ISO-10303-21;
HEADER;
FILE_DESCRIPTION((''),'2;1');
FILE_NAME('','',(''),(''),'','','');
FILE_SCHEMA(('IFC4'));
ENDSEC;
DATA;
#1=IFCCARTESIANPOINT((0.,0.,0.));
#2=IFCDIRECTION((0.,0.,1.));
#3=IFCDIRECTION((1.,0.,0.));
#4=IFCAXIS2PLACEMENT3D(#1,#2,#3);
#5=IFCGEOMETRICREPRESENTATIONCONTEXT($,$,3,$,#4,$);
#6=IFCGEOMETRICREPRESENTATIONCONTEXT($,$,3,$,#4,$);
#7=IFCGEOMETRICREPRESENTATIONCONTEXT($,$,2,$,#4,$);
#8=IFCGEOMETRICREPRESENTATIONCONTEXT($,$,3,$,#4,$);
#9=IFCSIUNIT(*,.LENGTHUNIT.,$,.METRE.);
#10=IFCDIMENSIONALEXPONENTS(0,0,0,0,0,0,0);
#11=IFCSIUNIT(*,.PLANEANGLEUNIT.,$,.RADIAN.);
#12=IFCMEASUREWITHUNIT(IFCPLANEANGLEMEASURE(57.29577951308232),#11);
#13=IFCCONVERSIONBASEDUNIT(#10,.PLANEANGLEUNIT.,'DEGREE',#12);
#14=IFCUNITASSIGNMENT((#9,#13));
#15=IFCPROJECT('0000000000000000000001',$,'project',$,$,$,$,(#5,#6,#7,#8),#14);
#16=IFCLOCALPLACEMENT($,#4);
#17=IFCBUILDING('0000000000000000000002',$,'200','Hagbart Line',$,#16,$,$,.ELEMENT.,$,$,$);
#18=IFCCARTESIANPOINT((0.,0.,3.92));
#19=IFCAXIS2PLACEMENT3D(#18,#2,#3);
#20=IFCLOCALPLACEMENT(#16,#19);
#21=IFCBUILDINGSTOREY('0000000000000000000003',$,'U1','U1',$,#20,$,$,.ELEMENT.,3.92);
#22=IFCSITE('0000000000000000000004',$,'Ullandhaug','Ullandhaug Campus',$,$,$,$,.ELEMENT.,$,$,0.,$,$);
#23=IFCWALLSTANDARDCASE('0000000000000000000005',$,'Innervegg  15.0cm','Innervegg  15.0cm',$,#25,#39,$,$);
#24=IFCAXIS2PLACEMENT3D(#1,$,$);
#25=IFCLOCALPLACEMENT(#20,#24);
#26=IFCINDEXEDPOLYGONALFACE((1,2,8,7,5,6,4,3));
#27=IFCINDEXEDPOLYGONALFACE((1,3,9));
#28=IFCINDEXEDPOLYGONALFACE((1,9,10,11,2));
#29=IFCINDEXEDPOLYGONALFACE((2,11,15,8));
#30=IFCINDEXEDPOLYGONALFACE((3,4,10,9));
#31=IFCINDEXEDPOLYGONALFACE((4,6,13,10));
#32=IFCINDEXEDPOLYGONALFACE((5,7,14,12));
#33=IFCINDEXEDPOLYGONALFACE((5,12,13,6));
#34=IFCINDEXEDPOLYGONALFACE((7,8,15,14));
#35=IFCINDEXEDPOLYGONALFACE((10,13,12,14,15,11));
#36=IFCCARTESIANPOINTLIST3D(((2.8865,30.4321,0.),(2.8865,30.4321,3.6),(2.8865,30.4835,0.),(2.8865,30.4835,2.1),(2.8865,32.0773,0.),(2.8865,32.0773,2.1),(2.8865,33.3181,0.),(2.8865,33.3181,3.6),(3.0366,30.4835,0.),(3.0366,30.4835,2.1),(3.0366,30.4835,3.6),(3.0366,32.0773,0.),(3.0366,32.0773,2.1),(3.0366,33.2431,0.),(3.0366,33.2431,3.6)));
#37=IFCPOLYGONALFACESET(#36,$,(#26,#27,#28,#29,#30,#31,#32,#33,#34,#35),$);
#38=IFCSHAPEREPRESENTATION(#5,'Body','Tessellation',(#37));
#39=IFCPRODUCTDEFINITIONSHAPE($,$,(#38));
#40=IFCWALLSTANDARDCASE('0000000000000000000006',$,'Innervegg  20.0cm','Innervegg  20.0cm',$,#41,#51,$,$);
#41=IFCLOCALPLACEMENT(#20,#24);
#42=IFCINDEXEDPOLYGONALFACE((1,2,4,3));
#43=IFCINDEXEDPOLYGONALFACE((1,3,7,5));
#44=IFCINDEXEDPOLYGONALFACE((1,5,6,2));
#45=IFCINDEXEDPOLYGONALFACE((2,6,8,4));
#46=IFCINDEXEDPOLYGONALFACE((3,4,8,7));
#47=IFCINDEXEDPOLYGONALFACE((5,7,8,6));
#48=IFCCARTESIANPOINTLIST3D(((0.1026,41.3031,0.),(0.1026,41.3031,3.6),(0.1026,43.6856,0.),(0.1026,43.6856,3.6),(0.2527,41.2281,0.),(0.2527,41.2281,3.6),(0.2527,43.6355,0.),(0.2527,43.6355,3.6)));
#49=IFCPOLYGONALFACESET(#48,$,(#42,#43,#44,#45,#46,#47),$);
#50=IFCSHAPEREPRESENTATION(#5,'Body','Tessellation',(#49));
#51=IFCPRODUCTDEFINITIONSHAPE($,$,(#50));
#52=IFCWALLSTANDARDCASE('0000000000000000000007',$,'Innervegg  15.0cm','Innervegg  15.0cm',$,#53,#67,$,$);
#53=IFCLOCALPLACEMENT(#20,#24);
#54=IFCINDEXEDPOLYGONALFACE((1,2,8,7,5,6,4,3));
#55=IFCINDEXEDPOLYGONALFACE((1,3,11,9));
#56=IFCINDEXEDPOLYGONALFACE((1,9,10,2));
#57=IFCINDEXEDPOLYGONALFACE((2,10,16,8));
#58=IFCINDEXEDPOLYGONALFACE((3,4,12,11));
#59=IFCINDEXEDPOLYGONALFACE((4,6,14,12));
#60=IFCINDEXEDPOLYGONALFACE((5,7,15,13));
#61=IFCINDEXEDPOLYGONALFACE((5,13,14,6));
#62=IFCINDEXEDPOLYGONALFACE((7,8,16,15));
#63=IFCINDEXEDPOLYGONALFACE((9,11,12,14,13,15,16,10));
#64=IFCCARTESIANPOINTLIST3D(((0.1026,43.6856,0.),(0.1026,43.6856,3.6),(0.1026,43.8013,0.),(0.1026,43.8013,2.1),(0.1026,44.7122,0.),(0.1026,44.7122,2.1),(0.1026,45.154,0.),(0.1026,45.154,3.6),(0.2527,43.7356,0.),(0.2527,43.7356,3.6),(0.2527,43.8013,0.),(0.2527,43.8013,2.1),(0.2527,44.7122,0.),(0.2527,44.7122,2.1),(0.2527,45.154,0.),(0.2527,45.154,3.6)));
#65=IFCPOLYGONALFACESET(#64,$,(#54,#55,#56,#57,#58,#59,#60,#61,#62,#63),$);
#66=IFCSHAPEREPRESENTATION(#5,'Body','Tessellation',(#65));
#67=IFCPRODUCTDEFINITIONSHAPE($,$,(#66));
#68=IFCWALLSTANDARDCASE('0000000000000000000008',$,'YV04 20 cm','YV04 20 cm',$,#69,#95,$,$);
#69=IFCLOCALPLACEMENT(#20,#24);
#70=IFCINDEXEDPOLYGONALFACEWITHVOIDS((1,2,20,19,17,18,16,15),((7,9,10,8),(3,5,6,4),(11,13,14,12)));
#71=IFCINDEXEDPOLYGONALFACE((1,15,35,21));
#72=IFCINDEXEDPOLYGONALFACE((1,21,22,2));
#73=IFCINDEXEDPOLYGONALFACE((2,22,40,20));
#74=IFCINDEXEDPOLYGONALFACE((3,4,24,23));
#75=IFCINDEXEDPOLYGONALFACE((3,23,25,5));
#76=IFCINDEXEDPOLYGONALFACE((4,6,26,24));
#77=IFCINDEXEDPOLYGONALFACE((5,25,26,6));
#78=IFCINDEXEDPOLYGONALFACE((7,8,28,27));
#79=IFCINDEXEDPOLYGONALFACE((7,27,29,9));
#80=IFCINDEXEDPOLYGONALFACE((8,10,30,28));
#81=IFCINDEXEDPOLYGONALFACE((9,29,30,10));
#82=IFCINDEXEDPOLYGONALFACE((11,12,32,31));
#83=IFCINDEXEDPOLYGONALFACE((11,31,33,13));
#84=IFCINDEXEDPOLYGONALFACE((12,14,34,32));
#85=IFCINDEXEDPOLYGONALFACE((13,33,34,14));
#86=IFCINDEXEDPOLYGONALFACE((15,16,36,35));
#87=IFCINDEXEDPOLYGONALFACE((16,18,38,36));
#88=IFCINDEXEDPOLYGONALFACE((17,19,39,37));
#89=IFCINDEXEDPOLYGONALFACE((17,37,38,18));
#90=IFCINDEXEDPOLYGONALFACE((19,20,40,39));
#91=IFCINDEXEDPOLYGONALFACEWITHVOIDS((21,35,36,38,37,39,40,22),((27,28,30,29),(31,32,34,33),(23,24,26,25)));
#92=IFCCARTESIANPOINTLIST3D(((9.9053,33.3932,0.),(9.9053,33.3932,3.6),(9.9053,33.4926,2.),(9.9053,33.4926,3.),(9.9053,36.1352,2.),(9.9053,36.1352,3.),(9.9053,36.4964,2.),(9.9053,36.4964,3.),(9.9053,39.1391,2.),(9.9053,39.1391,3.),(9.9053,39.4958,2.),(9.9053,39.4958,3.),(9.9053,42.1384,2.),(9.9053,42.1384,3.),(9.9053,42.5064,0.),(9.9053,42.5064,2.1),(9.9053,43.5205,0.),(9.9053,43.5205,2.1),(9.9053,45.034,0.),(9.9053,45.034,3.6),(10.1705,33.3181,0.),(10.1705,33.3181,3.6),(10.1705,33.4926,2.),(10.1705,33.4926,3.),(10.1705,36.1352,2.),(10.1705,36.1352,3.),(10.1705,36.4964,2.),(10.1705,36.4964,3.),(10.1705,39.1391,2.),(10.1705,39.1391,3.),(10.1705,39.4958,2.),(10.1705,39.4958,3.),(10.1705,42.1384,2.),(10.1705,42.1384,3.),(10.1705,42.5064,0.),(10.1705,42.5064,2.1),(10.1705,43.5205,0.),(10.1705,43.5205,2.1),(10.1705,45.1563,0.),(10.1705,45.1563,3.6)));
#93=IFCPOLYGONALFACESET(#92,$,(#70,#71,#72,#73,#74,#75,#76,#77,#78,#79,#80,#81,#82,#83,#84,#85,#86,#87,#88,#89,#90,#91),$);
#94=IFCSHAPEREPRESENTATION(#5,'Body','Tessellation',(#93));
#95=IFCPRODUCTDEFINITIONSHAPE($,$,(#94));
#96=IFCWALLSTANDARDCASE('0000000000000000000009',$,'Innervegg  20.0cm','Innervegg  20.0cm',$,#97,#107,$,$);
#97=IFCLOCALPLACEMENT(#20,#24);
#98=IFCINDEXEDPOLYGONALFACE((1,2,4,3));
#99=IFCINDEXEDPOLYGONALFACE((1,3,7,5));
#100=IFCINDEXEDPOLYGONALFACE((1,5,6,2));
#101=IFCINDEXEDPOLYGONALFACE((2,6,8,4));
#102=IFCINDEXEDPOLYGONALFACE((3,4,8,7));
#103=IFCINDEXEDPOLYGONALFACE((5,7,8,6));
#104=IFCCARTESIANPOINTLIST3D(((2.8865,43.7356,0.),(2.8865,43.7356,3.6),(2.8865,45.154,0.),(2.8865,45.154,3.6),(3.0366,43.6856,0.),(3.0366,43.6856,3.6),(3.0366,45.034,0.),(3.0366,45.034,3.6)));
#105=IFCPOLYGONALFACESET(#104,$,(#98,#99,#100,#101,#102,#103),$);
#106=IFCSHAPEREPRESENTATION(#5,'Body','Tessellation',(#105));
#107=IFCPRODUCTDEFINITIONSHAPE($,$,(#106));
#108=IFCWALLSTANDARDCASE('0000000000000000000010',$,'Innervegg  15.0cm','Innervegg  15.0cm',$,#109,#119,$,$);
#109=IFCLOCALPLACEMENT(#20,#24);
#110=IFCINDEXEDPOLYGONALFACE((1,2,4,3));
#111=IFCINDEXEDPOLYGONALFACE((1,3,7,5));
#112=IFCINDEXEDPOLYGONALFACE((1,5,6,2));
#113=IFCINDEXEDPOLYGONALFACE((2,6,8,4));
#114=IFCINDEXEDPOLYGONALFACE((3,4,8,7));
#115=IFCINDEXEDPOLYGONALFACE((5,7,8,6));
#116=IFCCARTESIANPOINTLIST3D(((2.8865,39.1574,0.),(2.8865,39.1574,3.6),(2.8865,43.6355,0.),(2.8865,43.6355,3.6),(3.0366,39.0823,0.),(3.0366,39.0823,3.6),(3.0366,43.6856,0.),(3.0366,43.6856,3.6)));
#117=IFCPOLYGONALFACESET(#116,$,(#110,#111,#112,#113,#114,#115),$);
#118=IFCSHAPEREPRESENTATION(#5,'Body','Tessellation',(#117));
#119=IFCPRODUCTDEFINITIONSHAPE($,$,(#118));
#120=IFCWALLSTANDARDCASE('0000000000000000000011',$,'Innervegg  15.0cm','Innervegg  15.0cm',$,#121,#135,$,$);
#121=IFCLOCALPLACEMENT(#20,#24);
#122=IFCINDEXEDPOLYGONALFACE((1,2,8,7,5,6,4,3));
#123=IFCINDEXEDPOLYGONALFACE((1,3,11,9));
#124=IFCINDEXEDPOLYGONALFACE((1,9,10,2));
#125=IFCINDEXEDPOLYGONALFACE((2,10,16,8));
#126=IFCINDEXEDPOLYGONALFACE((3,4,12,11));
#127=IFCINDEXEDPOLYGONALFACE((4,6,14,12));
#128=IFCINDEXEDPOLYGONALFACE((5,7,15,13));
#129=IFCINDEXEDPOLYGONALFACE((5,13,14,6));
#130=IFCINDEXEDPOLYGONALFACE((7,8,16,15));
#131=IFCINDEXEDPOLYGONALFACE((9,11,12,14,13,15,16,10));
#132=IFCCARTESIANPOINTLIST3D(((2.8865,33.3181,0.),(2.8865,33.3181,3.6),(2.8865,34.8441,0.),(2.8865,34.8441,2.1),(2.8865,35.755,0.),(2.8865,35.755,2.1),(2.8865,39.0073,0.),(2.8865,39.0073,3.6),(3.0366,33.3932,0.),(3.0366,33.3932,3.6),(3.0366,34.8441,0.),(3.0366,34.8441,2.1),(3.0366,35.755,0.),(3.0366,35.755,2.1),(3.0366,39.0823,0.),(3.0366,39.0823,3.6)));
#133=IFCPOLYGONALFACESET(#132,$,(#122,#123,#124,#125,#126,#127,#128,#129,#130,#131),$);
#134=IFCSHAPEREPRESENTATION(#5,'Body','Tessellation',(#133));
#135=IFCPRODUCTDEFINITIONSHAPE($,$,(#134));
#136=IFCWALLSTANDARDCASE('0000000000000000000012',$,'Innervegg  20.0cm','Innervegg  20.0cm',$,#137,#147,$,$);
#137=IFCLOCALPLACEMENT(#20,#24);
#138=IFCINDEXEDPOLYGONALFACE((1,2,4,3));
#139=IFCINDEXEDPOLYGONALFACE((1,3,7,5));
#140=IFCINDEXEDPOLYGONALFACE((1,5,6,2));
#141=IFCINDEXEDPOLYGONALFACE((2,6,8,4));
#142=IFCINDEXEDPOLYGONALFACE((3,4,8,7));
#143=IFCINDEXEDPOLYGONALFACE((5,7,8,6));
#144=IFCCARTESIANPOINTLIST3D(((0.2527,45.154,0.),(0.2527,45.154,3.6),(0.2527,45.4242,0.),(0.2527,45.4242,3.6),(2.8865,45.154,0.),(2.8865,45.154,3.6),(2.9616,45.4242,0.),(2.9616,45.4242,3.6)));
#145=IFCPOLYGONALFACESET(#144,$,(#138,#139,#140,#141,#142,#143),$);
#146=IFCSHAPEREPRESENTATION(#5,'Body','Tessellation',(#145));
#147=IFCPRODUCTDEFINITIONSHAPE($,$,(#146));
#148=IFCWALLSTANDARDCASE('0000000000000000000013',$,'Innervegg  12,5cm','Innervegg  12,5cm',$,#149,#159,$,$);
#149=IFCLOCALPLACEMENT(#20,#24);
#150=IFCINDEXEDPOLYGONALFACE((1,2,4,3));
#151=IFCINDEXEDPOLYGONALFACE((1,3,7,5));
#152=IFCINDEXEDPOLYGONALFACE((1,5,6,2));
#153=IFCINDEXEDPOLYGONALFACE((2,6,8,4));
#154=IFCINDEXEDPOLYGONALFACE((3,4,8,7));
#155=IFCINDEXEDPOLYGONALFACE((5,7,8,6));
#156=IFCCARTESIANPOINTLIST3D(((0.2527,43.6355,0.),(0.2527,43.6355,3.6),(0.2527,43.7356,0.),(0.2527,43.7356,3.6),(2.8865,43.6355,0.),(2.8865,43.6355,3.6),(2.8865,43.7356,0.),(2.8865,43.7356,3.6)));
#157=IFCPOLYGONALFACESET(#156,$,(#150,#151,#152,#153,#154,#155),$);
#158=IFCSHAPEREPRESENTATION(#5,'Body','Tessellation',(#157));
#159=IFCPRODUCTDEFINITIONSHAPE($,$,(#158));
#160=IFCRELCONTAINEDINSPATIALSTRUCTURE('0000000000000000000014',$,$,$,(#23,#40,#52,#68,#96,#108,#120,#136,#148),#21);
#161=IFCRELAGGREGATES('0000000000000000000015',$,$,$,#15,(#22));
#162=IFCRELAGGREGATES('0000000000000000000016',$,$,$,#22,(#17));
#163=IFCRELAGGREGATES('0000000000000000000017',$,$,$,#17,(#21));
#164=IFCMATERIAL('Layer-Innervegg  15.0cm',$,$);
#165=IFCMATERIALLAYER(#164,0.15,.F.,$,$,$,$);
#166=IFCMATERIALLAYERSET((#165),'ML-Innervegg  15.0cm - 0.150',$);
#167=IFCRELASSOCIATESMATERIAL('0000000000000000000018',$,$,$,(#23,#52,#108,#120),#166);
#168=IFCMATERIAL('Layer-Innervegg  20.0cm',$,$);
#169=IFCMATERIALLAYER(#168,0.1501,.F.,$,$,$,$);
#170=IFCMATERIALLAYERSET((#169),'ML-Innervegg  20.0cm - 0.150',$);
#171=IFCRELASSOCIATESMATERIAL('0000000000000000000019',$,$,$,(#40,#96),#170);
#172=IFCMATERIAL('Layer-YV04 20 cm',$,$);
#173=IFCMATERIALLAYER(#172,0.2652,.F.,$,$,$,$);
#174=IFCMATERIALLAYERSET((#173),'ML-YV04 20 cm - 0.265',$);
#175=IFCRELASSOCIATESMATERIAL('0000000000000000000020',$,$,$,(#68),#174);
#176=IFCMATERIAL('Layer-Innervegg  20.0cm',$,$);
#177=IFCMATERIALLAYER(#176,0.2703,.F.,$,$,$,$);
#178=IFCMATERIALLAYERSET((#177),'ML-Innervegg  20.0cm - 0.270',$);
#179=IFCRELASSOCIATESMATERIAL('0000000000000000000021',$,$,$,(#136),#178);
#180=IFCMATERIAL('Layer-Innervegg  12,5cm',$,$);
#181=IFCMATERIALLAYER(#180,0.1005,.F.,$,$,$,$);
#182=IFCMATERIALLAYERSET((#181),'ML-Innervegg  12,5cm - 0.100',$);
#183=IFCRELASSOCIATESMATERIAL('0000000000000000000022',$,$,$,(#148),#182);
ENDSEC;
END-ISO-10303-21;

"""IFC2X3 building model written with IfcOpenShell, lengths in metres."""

from ifc_helpers import new_model, entity, si_unit, converted_unit, frame, origin_with_axes, place, context, project, spatial, polyline, outline, extrude, material, layer, layer_set, layer_usage, element, save


model = new_model("IFC2X3")

# Units and contexts
context_of_model_1 = context(None, 3, world=origin_with_axes())
context_of_model_2 = context(None, 3, world=origin_with_axes())
context_of_model_3 = context(None, 2, world=origin_with_axes())
context_of_model_4 = context(None, 3, world=origin_with_axes())
ifc_project = project(units=[si_unit("LENGTHUNIT", "METRE"), converted_unit("PLANEANGLEUNIT", "DEGREE", entity("IfcPlaneAngleMeasure", 57.29577951308232), si_unit("PLANEANGLEUNIT", "RADIAN"), dimensions=[0, 0, 0, 0, 0, 0, 0])], contexts=[context_of_model_1, context_of_model_2, context_of_model_3, context_of_model_4])

# Site, building, storey
site = spatial("IfcSite", under=ifc_project, Name="Ullandhaug", Description="Ullandhaug Campus", CompositionType="ELEMENT", RefElevation=0.0)
building_placement = place(None, origin_with_axes())
building = spatial("IfcBuilding", under=site, at=building_placement, Name="200", Description="Hagbart Line", CompositionType="ELEMENT")
storey_placement = place(building_placement, frame((0.0, 0.0, 3.92), z_axis=(0.0, 0.0, 1.0), x_axis=(1.0, 0.0, 0.0)))
storey = spatial("IfcBuildingStorey", under=building, at=storey_placement, Name="U1", Description="U1", CompositionType="ELEMENT", Elevation=3.92)

# Shared definitions
ifc_material_1 = material(Name="Layer-Innervegg  15.0cm")
ifc_layer_1 = layer(ifc_material_1, 0.15, ventilated=False)
ifc_layer_set_1 = layer_set([ifc_layer_1], Name="ML-Innervegg  15.0cm - 0.150")
ifc_layer_usage_1 = layer_usage(ifc_layer_set_1, "AXIS2", "POSITIVE", 0.0)

# Wall, opening
wall_1_placement = place(storey_placement, frame((2.8865, 33.3181, 0.0), z_axis=(0.0, 0.0, 1.0), x_axis=(0.0, -1.0, 0.0)))
wall_1 = element("IfcWallStandardCase", 1, at=wall_1_placement, inside=storey, material=ifc_layer_usage_1, Name="Innervegg  15.0cm", Description="Innervegg  15.0cm", context=context_of_model_1, shape_type="SweptSolid", body=[
    extrude(outline(polyline([(0.0, 0.0), (2.8861, 0.0), (2.8347, 0.1502), (0.0751, 0.1502), (0.0, 0.0)])), frame((0.0, 0.0, 0.0), z_axis=(0.0, 0.0, 1.0), x_axis=(1.0, 0.0, 0.0)), (0.0, 0.0, 1.0), 3.6),
])
opening_1_placement = place(wall_1_placement, frame((1.2408, 0.1502, 0.0), z_axis=(0.0, 0.0, 1.0), x_axis=(1.0, 0.0, 0.0)))
element("IfcOpeningElement", 2, at=opening_1_placement, cuts=wall_1, context=context_of_model_1, shape_type="SweptSolid", body=[
    extrude(outline(polyline([(0.0, 0.0), (2.1, 0.0), (2.1, 1.5938), (0.0, 1.5938), (0.0, 0.0)])), frame((0.0, 0.0, 0.0), z_axis=(0.0, 1.0, 0.0), x_axis=(0.0, 0.0, 1.0)), (0.0, 0.0, -1.0), 0.1502),
])

# Wall
ifc_material_2 = material(Name="Layer-Innervegg  20.0cm")
ifc_layer_2 = layer(ifc_material_2, 0.1501, ventilated=False)
ifc_layer_set_2 = layer_set([ifc_layer_2], Name="ML-Innervegg  20.0cm - 0.150")
ifc_layer_usage_2 = layer_usage(ifc_layer_set_2, "AXIS2", "POSITIVE", 0.0)
wall_2_placement = place(storey_placement, frame((0.2527, 41.2281, 0.0), z_axis=(0.0, 0.0, 1.0), x_axis=(0.0, 1.0, 0.0)))
element("IfcWallStandardCase", 3, at=wall_2_placement, inside=storey, material=ifc_layer_usage_2, Name="Innervegg  20.0cm", Description="Innervegg  20.0cm", context=context_of_model_1, shape_type="SweptSolid", body=[
    extrude(outline(polyline([(0.0, 0.0), (2.4075, 0.0), (2.4575, 0.1501), (0.0751, 0.1501), (0.0, 0.0)])), frame((0.0, 0.0, 0.0), z_axis=(0.0, 0.0, 1.0), x_axis=(1.0, 0.0, 0.0)), (0.0, 0.0, 1.0), 3.6),
])

# Wall, opening
wall_3_placement = place(storey_placement, frame((0.2527, 43.7356, 0.0), z_axis=(0.0, 0.0, 1.0), x_axis=(0.0, 1.0, 0.0)))
wall_3 = element("IfcWallStandardCase", 4, at=wall_3_placement, inside=storey, material=ifc_layer_usage_1, Name="Innervegg  15.0cm", Description="Innervegg  15.0cm", context=context_of_model_1, shape_type="SweptSolid", body=[
    extrude(outline(polyline([(0.0, 0.0), (1.4184, 0.0), (1.4184, 0.1501), (-0.05, 0.1502), (0.0, 0.0)])), frame((0.0, 0.0, 0.0), z_axis=(0.0, 0.0, 1.0), x_axis=(1.0, 0.0, 0.0)), (0.0, 0.0, 1.0), 3.6),
])
opening_2_placement = place(wall_3_placement, frame((0.0656, 0.1502, 0.0), z_axis=(0.0, 0.0, 1.0), x_axis=(1.0, 0.0, 0.0)))
element("IfcOpeningElement", 5, at=opening_2_placement, cuts=wall_3, context=context_of_model_1, shape_type="SweptSolid", body=[
    extrude(outline(polyline([(0.0, 0.0), (2.1, 0.0), (2.1, 0.9109), (0.0, 0.9109), (0.0, 0.0)])), frame((0.0, 0.0, 0.0), z_axis=(0.0, 1.0, 0.0), x_axis=(0.0, 0.0, 1.0)), (0.0, 0.0, -1.0), 0.1501),
])

# Wall, openings
ifc_material_3 = material(Name="Layer-YV04 20 cm")
ifc_layer_3 = layer(ifc_material_3, 0.2652, ventilated=False)
ifc_layer_set_3 = layer_set([ifc_layer_3], Name="ML-YV04 20 cm - 0.265")
ifc_layer_usage_3 = layer_usage(ifc_layer_set_3, "AXIS2", "POSITIVE", 0.0)
wall_4_placement = place(storey_placement, frame((10.1705, 33.3181, 0.0), z_axis=(0.0, 0.0, 1.0), x_axis=(0.0, 1.0, 0.0)))
wall_4 = element("IfcWallStandardCase", 6, at=wall_4_placement, inside=storey, material=ifc_layer_usage_3, Name="YV04 20 cm", Description="YV04 20 cm", context=context_of_model_1, shape_type="SweptSolid", body=[
    extrude(outline(polyline([(0.0, 0.0), (11.8382, 0.0), (11.7158, 0.2652), (0.0751, 0.2652), (0.0, 0.0)])), frame((0.0, 0.0, 0.0), z_axis=(0.0, 0.0, 1.0), x_axis=(1.0, 0.0, 0.0)), (0.0, 0.0, 1.0), 3.6),
])
opening_3_placement = place(wall_4_placement, frame((9.1883, 0.2652, 0.0), z_axis=(0.0, 0.0, 1.0), x_axis=(1.0, 0.0, 0.0)))
element("IfcOpeningElement", 7, at=opening_3_placement, cuts=wall_4, context=context_of_model_1, shape_type="SweptSolid", body=[
    extrude(outline(polyline([(0.0, 0.0), (2.1, 0.0), (2.1, 1.0141), (0.0, 1.0141), (0.0, 0.0)])), frame((0.0, 0.0, 0.0), z_axis=(0.0, 1.0, 0.0), x_axis=(0.0, 0.0, 1.0)), (0.0, 0.0, -1.0), 0.2652),
])
opening_4_placement = place(wall_4_placement, frame((0.1744, 0.2652, 2.0), z_axis=(0.0, 0.0, 1.0), x_axis=(1.0, 0.0, 0.0)))
element("IfcOpeningElement", 8, at=opening_4_placement, cuts=wall_4, context=context_of_model_1, shape_type="SweptSolid", body=[
    extrude(outline(polyline([(0.0, 0.0), (1.0, 0.0), (1.0, 2.6426), (0.0, 2.6426), (0.0, 0.0)])), frame((0.0, 0.0, 0.0), z_axis=(0.0, 1.0, 0.0), x_axis=(0.0, 0.0, 1.0)), (0.0, 0.0, -1.0), 0.2652),
])
opening_5_placement = place(wall_4_placement, frame((3.1783, 0.2652, 2.0), z_axis=(0.0, 0.0, 1.0), x_axis=(1.0, 0.0, 0.0)))
element("IfcOpeningElement", 9, at=opening_5_placement, cuts=wall_4, context=context_of_model_1, shape_type="SweptSolid", body=[
    extrude(outline(polyline([(0.0, 0.0), (1.0, 0.0), (1.0, 2.6426), (0.0, 2.6426), (0.0, 0.0)])), frame((0.0, 0.0, 0.0), z_axis=(0.0, 1.0, 0.0), x_axis=(0.0, 0.0, 1.0)), (0.0, 0.0, -1.0), 0.2652),
])
opening_6_placement = place(wall_4_placement, frame((6.1776, 0.2652, 2.0), z_axis=(0.0, 0.0, 1.0), x_axis=(1.0, 0.0, 0.0)))
element("IfcOpeningElement", 10, at=opening_6_placement, cuts=wall_4, context=context_of_model_1, shape_type="SweptSolid", body=[
    extrude(outline(polyline([(0.0, 0.0), (1.0, 0.0), (1.0, 2.6426), (0.0, 2.6426), (0.0, 0.0)])), frame((0.0, 0.0, 0.0), z_axis=(0.0, 1.0, 0.0), x_axis=(0.0, 0.0, 1.0)), (0.0, 0.0, -1.0), 0.2652),
])

# Walls
wall_5_placement = place(storey_placement, frame((2.8865, 45.154, 0.0), z_axis=(0.0, 0.0, 1.0), x_axis=(0.0, -1.0, 0.0)))
element("IfcWallStandardCase", 11, at=wall_5_placement, inside=storey, material=ifc_layer_usage_2, Name="Innervegg  20.0cm", Description="Innervegg  20.0cm", context=context_of_model_1, shape_type="SweptSolid", body=[
    extrude(outline(polyline([(0.0, 0.0), (1.4184, 0.0), (1.4684, 0.1501), (0.12, 0.1501), (0.0, 0.0)])), frame((0.0, 0.0, 0.0), z_axis=(0.0, 0.0, 1.0), x_axis=(1.0, 0.0, 0.0)), (0.0, 0.0, 1.0), 3.6),
])
wall_6_placement = place(storey_placement, frame((2.8865, 43.6355, 0.0), z_axis=(0.0, 0.0, 1.0), x_axis=(0.0, -1.0, 0.0)))
element("IfcWallStandardCase", 12, at=wall_6_placement, inside=storey, material=ifc_layer_usage_1, Name="Innervegg  15.0cm", Description="Innervegg  15.0cm", context=context_of_model_1, shape_type="SweptSolid", body=[
    extrude(outline(polyline([(0.0, 0.0), (4.4781, 0.0), (4.5532, 0.1501), (-0.05, 0.1501), (0.0, 0.0)])), frame((0.0, 0.0, 0.0), z_axis=(0.0, 0.0, 1.0), x_axis=(1.0, 0.0, 0.0)), (0.0, 0.0, 1.0), 3.6),
])

# Wall, opening
wall_7_placement = place(storey_placement, frame((2.8865, 39.0073, 0.0), z_axis=(0.0, 0.0, 1.0), x_axis=(0.0, -1.0, 0.0)))
wall_7 = element("IfcWallStandardCase", 13, at=wall_7_placement, inside=storey, material=ifc_layer_usage_1, Name="Innervegg  15.0cm", Description="Innervegg  15.0cm", context=context_of_model_1, shape_type="SweptSolid", body=[
    extrude(outline(polyline([(0.0, 0.0), (5.6891, 0.0), (5.614, 0.1502), (-0.0751, 0.1502), (0.0, 0.0)])), frame((0.0, 0.0, 0.0), z_axis=(0.0, 0.0, 1.0), x_axis=(1.0, 0.0, 0.0)), (0.0, 0.0, 1.0), 3.6),
])
opening_7_placement = place(wall_7_placement, frame((3.2523, 0.1502, 0.0), z_axis=(0.0, 0.0, 1.0), x_axis=(1.0, 0.0, 0.0)))
element("IfcOpeningElement", 14, at=opening_7_placement, cuts=wall_7, context=context_of_model_1, shape_type="SweptSolid", body=[
    extrude(outline(polyline([(0.0, 0.0), (2.1, 0.0), (2.1, 0.9109), (0.0, 0.9109), (0.0, 0.0)])), frame((0.0, 0.0, 0.0), z_axis=(0.0, 1.0, 0.0), x_axis=(0.0, 0.0, 1.0)), (0.0, 0.0, -1.0), 0.1502),
])

# Walls
ifc_material_4 = material(Name="Layer-Innervegg  20.0cm")
ifc_layer_4 = layer(ifc_material_4, 0.2703, ventilated=False)
ifc_layer_set_4 = layer_set([ifc_layer_4], Name="ML-Innervegg  20.0cm - 0.270")
ifc_layer_usage_4 = layer_usage(ifc_layer_set_4, "AXIS2", "POSITIVE", 0.0)
wall_8_placement = place(storey_placement, frame((0.2527, 45.154, 0.0), z_axis=(0.0, 0.0, 1.0), x_axis=(1.0, 0.0, 0.0)))
element("IfcWallStandardCase", 15, at=wall_8_placement, inside=storey, material=ifc_layer_usage_4, Name="Innervegg  20.0cm", Description="Innervegg  20.0cm", context=context_of_model_1, shape_type="SweptSolid", body=[
    extrude(outline(polyline([(0.0, 0.0), (2.6338, 0.0), (2.7088, 0.2703), (0.0, 0.2703), (0.0, 0.0)])), origin_with_axes(), (0.0, 0.0, 1.0), 3.6),
])
ifc_material_5 = material(Name="Layer-Innervegg  12,5cm")
ifc_layer_5 = layer(ifc_material_5, 0.1005, ventilated=False)
ifc_layer_set_5 = layer_set([ifc_layer_5], Name="ML-Innervegg  12,5cm - 0.100")
ifc_layer_usage_5 = layer_usage(ifc_layer_set_5, "AXIS2", "POSITIVE", 0.0)
wall_9_placement = place(storey_placement, frame((0.2527, 43.6355, 0.0), z_axis=(0.0, 0.0, 1.0), x_axis=(1.0, 0.0, 0.0)))
element("IfcWallStandardCase", 16, at=wall_9_placement, inside=storey, material=ifc_layer_usage_5, Name="Innervegg  12,5cm", Description="Innervegg  12,5cm", context=context_of_model_1, shape_type="SweptSolid", body=[
    extrude(outline(polyline([(0.0, 0.0), (2.6338, 0.0), (2.6338, 0.1001), (0.0, 0.1001), (0.0, 0.0)])), origin_with_axes(), (0.0, 0.0, 1.0), 3.6),
])

save(model, "model.ifc")
